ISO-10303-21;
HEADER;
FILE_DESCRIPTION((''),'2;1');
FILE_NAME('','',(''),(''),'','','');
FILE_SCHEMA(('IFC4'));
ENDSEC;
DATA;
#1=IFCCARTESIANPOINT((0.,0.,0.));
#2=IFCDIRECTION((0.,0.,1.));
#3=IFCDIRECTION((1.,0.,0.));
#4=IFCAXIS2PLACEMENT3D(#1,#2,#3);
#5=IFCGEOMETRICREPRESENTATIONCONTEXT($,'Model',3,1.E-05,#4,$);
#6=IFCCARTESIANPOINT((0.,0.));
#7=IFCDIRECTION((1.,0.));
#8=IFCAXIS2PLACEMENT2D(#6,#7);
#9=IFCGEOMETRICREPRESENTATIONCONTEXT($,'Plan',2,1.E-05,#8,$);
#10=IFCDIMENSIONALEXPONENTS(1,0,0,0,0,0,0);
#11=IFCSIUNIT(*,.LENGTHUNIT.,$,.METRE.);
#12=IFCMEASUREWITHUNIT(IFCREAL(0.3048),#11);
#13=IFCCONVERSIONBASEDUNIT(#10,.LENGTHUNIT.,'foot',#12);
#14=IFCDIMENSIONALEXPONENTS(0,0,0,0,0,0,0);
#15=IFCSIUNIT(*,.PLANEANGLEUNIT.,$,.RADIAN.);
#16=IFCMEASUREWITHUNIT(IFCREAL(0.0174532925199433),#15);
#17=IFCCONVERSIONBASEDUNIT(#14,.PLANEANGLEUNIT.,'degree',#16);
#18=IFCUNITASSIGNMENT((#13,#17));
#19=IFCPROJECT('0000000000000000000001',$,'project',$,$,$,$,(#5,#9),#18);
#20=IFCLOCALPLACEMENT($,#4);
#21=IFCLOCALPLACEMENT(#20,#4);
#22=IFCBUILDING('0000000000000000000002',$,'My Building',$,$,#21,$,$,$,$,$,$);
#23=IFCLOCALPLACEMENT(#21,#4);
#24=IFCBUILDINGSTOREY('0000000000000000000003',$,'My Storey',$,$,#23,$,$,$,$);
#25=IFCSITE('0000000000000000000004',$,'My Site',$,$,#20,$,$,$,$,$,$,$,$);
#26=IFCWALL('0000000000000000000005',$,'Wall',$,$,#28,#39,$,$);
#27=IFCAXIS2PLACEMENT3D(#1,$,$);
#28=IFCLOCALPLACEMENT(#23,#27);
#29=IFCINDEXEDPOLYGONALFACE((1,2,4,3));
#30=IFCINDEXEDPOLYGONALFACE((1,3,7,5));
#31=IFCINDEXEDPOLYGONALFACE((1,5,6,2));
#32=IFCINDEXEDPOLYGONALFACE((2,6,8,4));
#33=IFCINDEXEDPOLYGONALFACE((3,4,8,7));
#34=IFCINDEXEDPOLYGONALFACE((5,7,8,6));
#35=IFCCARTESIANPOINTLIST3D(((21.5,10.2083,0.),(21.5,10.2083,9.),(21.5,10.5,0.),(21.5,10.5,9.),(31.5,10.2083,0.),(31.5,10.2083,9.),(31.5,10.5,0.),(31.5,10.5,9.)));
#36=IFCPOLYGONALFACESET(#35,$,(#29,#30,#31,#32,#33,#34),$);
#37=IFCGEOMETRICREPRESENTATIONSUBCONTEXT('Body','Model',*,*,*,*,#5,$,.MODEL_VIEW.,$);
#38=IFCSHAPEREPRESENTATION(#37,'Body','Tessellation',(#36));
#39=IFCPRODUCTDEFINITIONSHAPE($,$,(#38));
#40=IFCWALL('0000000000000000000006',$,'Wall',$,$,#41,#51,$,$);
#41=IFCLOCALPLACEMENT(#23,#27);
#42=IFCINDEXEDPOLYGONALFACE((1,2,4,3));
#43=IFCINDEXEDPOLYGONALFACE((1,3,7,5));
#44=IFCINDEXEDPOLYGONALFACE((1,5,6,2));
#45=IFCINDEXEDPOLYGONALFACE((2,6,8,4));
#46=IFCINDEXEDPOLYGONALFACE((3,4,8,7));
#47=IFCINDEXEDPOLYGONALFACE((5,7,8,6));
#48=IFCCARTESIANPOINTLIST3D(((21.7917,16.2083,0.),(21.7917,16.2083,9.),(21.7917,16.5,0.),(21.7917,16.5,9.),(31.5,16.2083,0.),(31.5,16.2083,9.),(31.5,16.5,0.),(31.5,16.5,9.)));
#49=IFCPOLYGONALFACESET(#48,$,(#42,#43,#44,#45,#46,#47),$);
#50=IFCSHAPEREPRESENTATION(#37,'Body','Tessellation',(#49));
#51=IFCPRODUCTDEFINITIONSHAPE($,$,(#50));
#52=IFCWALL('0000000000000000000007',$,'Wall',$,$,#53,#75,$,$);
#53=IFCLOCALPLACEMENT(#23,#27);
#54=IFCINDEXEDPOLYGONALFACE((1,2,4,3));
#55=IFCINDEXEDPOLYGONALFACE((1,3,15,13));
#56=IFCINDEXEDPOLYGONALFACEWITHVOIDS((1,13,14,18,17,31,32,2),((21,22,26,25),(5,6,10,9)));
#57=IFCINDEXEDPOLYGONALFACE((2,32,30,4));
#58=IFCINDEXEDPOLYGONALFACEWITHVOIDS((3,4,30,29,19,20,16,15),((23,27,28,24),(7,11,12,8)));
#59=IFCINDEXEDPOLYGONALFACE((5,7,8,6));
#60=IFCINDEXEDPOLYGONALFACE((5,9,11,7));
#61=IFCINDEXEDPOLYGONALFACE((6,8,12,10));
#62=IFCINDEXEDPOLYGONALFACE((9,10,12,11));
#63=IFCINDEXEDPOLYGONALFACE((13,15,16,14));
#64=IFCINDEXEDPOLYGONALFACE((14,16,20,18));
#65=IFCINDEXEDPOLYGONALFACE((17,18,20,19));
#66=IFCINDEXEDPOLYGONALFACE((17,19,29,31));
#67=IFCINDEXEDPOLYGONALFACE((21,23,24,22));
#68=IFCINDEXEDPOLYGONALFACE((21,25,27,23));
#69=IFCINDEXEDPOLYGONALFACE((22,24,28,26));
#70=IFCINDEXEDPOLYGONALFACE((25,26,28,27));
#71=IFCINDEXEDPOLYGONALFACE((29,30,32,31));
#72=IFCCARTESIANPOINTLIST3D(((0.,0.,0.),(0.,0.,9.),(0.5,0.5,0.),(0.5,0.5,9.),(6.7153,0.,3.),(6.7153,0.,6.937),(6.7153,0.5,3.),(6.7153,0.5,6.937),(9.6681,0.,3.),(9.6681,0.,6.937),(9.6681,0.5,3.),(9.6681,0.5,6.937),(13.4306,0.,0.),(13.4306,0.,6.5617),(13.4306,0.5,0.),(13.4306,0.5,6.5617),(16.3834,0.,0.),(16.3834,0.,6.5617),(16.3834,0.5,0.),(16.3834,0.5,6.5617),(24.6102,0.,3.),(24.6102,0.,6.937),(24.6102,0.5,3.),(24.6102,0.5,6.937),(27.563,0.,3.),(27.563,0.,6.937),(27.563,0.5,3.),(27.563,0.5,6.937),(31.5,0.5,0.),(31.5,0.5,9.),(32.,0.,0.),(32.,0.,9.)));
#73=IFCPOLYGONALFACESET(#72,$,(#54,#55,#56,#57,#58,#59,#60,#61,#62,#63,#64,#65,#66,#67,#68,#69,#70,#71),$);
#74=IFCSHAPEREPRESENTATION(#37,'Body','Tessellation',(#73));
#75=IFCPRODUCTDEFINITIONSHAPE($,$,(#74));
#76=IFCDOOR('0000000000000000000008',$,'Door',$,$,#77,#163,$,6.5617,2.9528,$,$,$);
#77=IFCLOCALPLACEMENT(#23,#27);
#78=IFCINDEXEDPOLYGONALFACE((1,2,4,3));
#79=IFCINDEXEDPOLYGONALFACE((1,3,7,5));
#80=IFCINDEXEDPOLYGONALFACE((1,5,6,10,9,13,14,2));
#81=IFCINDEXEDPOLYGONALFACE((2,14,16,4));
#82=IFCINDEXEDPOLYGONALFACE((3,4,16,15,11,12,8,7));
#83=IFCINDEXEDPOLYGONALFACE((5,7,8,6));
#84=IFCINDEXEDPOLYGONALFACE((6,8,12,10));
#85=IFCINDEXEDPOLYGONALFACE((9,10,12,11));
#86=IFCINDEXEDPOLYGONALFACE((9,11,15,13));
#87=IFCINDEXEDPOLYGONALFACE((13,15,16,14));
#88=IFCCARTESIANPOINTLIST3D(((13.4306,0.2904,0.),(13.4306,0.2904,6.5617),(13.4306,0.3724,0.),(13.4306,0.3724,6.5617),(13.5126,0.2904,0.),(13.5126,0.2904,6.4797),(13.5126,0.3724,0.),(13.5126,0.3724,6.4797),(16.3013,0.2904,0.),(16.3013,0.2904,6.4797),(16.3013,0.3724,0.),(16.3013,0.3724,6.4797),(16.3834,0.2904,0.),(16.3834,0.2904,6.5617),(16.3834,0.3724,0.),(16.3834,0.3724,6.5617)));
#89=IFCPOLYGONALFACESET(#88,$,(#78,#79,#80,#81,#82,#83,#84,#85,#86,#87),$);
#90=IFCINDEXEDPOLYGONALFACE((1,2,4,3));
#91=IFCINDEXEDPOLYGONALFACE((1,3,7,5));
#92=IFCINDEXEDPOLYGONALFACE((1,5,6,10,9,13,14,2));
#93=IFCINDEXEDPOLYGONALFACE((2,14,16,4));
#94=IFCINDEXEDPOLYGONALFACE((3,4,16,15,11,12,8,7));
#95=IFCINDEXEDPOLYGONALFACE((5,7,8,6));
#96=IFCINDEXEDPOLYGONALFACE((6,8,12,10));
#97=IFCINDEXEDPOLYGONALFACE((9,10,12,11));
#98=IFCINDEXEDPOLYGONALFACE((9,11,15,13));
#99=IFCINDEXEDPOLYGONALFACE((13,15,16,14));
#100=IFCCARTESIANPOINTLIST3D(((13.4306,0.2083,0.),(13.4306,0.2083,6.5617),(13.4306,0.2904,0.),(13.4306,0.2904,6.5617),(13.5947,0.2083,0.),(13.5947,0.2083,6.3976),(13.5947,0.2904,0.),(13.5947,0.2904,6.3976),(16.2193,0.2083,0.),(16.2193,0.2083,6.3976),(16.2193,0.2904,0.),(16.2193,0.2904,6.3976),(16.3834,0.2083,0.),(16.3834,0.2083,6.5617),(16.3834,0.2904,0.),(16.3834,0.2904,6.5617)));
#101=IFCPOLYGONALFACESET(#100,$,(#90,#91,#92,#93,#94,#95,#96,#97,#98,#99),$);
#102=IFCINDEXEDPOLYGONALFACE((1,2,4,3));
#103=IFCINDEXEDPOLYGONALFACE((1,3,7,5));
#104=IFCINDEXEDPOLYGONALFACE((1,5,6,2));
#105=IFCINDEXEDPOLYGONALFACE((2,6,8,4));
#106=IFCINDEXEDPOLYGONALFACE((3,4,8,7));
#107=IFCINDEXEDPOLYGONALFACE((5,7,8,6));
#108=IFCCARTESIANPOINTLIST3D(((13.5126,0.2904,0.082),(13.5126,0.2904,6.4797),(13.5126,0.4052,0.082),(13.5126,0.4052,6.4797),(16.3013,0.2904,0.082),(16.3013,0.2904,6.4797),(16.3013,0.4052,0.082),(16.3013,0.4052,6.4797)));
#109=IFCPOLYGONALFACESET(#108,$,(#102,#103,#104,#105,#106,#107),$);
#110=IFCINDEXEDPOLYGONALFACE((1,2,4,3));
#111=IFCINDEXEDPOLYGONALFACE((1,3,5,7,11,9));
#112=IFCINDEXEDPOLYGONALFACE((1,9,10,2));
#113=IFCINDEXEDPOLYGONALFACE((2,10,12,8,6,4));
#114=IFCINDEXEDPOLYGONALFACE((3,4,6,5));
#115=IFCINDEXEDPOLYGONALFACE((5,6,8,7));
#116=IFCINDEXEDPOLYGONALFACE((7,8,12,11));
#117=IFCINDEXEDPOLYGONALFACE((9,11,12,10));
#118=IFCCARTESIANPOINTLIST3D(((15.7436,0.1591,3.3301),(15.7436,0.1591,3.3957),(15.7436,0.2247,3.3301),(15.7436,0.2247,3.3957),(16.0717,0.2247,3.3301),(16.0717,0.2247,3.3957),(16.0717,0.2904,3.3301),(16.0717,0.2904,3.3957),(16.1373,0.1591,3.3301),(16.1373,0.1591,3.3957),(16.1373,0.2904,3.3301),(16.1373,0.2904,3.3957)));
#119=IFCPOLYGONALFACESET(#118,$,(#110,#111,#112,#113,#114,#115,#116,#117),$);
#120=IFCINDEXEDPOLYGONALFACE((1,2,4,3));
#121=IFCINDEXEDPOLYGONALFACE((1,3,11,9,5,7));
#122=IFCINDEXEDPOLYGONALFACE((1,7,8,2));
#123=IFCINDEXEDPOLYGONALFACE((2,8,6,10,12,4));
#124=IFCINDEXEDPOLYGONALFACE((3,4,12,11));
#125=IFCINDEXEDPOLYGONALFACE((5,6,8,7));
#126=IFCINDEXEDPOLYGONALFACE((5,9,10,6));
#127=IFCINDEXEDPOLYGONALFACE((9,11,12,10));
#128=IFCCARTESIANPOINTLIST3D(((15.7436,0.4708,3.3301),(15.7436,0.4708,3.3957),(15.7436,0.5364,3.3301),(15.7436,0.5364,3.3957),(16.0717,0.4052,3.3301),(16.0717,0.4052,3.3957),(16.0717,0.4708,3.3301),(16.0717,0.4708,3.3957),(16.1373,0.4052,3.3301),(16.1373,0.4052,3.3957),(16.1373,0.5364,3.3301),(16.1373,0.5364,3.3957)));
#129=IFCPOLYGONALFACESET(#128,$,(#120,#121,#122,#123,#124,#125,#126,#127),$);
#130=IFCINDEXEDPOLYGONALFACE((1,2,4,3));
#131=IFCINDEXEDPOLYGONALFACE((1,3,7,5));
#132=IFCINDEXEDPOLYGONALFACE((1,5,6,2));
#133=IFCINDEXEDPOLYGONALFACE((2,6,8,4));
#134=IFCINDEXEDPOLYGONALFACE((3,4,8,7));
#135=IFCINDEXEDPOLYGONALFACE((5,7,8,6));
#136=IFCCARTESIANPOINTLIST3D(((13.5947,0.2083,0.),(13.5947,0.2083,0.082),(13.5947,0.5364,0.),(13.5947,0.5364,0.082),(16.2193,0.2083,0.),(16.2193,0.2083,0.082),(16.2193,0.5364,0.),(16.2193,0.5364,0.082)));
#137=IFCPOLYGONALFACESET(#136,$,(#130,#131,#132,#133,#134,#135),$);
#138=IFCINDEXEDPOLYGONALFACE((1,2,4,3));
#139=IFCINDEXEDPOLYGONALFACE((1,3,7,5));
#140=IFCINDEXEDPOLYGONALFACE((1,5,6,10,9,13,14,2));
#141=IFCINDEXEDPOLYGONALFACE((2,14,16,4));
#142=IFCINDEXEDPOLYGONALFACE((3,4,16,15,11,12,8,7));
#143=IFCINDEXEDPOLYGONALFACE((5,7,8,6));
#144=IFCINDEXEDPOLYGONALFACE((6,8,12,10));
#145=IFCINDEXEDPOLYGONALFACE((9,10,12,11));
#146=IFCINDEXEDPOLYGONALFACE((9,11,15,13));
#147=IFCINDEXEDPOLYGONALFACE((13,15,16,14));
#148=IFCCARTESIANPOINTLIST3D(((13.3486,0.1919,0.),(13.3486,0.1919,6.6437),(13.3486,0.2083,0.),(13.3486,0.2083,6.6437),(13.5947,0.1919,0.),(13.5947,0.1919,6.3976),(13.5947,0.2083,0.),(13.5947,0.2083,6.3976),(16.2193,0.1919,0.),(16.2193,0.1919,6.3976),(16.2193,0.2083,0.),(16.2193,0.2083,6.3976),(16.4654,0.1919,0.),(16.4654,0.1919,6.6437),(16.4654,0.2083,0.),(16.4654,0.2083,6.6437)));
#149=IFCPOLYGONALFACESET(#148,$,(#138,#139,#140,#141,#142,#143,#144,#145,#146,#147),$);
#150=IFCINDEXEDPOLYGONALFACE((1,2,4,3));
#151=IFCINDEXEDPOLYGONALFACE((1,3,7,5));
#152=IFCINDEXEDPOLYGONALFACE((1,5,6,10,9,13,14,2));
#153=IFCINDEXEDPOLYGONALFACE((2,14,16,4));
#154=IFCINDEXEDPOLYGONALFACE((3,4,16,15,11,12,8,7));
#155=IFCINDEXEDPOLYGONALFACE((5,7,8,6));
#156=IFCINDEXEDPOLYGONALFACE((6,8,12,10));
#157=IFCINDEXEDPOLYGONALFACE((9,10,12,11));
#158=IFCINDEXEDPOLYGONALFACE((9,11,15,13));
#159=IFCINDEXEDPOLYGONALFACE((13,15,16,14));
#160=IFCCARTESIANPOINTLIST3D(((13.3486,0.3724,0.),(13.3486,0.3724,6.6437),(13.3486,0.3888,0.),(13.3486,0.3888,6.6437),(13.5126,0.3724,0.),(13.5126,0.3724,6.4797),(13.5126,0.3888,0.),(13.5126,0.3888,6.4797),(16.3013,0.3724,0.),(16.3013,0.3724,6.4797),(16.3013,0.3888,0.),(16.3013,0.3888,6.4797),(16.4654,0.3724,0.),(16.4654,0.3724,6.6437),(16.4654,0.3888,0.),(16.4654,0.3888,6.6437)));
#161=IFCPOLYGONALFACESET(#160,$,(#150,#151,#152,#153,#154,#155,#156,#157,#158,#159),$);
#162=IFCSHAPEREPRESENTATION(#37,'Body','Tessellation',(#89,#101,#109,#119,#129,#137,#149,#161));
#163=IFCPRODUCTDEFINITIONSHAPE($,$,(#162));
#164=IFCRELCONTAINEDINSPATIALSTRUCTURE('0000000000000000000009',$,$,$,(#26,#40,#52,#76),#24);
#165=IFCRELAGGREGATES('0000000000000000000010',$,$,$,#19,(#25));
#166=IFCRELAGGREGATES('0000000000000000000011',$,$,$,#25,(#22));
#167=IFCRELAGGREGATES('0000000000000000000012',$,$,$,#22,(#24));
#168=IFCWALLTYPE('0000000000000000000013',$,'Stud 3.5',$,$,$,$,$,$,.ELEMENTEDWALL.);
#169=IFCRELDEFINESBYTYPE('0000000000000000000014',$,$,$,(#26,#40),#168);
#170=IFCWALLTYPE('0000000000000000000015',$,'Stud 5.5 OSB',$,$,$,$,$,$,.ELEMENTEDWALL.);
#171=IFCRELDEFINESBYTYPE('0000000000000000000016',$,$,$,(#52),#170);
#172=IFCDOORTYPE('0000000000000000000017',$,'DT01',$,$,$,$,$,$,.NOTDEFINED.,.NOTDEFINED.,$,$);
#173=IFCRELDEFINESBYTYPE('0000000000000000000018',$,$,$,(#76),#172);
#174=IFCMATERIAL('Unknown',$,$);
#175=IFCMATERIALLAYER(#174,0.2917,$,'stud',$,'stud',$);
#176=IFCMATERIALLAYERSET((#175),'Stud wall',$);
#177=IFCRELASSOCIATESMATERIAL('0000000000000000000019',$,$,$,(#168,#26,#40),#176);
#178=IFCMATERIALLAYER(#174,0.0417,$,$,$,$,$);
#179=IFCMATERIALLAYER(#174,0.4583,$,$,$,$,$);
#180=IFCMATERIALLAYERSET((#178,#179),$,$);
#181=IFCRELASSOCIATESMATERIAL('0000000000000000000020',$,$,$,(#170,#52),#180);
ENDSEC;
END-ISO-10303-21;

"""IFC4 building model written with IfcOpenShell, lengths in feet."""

from ifc_helpers import new_model, entity, si_unit, converted_unit, frame, origin_with_axes, origin_2d_with_axis, place, context, subcontext, project, spatial, line, indexed_curve, outline, extrude, clip, halfspace, shape, source, transform, mapped, material, layer, layer_set, layer_usage, type_object, type_shapes, element, fill, save


model = new_model("IFC4")

# Units and contexts
model_context = context("Model", 3, precision=1e-05, world=origin_with_axes())
plan_context = context("Plan", 2, precision=1e-05, world=origin_2d_with_axis())
body_context_1 = subcontext(model_context, "Body", "Model", "MODEL_VIEW")
body_context_2 = subcontext(plan_context, "Body", "Plan", "PLAN_VIEW")
ifc_project = project(units=[converted_unit("LENGTHUNIT", "foot", entity("IfcReal", 0.3048), si_unit("LENGTHUNIT", "METRE"), dimensions=[1, 0, 0, 0, 0, 0, 0]), converted_unit("PLANEANGLEUNIT", "degree", entity("IfcReal", 0.0174532925199433), si_unit("PLANEANGLEUNIT", "RADIAN"), dimensions=[0, 0, 0, 0, 0, 0, 0])], contexts=[model_context, plan_context])

# Site, building, storey
site_placement = place(None, origin_with_axes())
site = spatial("IfcSite", under=ifc_project, at=site_placement, Name="My Site")
building_placement = place(site_placement, origin_with_axes())
building = spatial("IfcBuilding", under=site, at=building_placement, Name="My Building")
storey_placement = place(building_placement, origin_with_axes())
storey = spatial("IfcBuildingStorey", under=building, at=storey_placement, Name="My Storey")

# Walls
ifc_material = material(Name="Unknown")
ifc_layer_1 = layer(ifc_material, 0.2917, Name="stud", Category="stud")
ifc_layer_set_1 = layer_set([ifc_layer_1], Name="Stud wall")
ifc_layer_usage_1 = layer_usage(ifc_layer_set_1, "AXIS2", "POSITIVE", 0.0)
wall_type_1 = type_object("IfcWallType", Name="Stud 3.5", PredefinedType="ELEMENTEDWALL", material=ifc_layer_set_1)
wall_1_placement = place(storey_placement, frame((31.5, 10.5, 0.0), z_axis=(0.0, 0.0, 1.0), x_axis=(-1.0, 0.000001, 0.0)))
element("IfcWall", 1, at=wall_1_placement, inside=storey, type_object=wall_type_1, material=ifc_layer_usage_1, Name="Wall", context=body_context_1, shape_type="SweptSolid", body=[
    extrude(outline(indexed_curve([(0.0, 0.0), (0.0, 0.2917), (10.0, 0.2917), (10.0, 0.0), (0.0, 0.0)], self_intersect=False)), origin_with_axes(), (0.0, 0.0, 1.0), 9.0),
])
ifc_layer_usage_2 = layer_usage(ifc_layer_set_1, "AXIS2", "POSITIVE", 0.0)
wall_2_placement = place(storey_placement, frame((31.5, 16.5, 0.0), z_axis=(0.0, 0.0, 1.0), x_axis=(-1.0, 0.000001, 0.0)))
element("IfcWall", 2, at=wall_2_placement, inside=storey, type_object=wall_type_1, material=ifc_layer_usage_2, Name="Wall", context=body_context_1, shape_type="SweptSolid", body=[
    extrude(outline(indexed_curve([(0.0, 0.0), (0.0, 0.2917), (9.7083, 0.2917), (9.7083, 0.0), (0.0, 0.0)], self_intersect=False)), origin_with_axes(), (0.0, 0.0, 1.0), 9.0),
])

# Wall, openings, door
ifc_layer_2 = layer(ifc_material, 0.0417)
ifc_layer_3 = layer(ifc_material, 0.4583)
ifc_layer_set_2 = layer_set([ifc_layer_2, ifc_layer_3])
ifc_layer_usage_3 = layer_usage(ifc_layer_set_2, "AXIS2", "POSITIVE", 0.0)
wall_type_2 = type_object("IfcWallType", Name="Stud 5.5 OSB", PredefinedType="ELEMENTEDWALL", material=ifc_layer_set_2)
wall_3_placement = place(storey_placement, origin_with_axes())
wall_3 = element("IfcWall", 3, at=wall_3_placement, inside=storey, type_object=wall_type_2, material=ifc_layer_usage_3, Name="Wall", context=body_context_1, shape_type="Clipping", body=[
    clip(clip(extrude(outline(indexed_curve([(0.0, 0.0), (0.0, 0.5), (32.0, 0.5), (32.0, 0.0), (0.0, 0.0)], self_intersect=False)), origin_with_axes(), (0.0, 0.0, 1.0), 9.0), halfspace(frame((32.0, 0.0, 0.0), z_axis=(0.707107, 0.707107, 0.0), x_axis=(0.707107, -0.707107, 0.0)), False)), halfspace(frame((0.0, 0.0, 0.0), z_axis=(-0.707106, 0.707107, 0.0), x_axis=(0.707107, 0.707106, 0.0)), False)),
])
shared_shape_1 = source(origin_with_axes(), body_context_1, "Body", "SweptSolid", [
    extrude(outline(indexed_curve([(0.0, 0.0), (2.9528, 0.0), (2.9528, 6.5617), (0.0, 6.5617)], segments=[line(1, 2, 3, 4, 1)])), frame((0.0, -1.9685, 0.0), z_axis=(0.0, -1.0, 0.0), x_axis=(1.0, 0.0, 0.0)), (0.0, 0.0, -1.0), 3.937),
])
opening_1_placement = place(wall_3_placement, frame((13.4306, 0.2083, 0.0), z_axis=(0.0, 0.0, 1.0), x_axis=(1.0, 0.0, 0.0)))
opening_1 = element("IfcOpeningElement", 4, at=opening_1_placement, cuts=wall_3, PredefinedType="OPENING", context=body_context_1, shape_type="MappedRepresentation", body=[
    mapped(shared_shape_1, transform((0.0, 0.0, 0.0), x_axis=(1.0, 0.0, 0.0), y_axis=(0.0, 1.0, 0.0), z_axis=(0.0, 0.0, 1.0), scale=1.0)),
])
shared_shape_2 = source(origin_with_axes(), body_context_1, "Body", "SweptSolid", [
    extrude(outline(indexed_curve([(0.0, 0.0), (2.9528, 0.0), (2.9528, 3.937), (0.0, 3.937)], segments=[line(1, 2, 3, 4, 1)])), frame((0.0, -1.9685, 0.0), z_axis=(0.0, -1.0, 0.0), x_axis=(1.0, 0.0, 0.0)), (0.0, 0.0, -1.0), 3.937),
])
opening_2_placement = place(wall_3_placement, frame((6.7153, 0.0, 3.0), z_axis=(0.0, 0.0, 1.0), x_axis=(1.0, 0.0, 0.0)))
element("IfcOpeningElement", 5, at=opening_2_placement, cuts=wall_3, PredefinedType="OPENING", context=body_context_1, shape_type="MappedRepresentation", body=[
    mapped(shared_shape_2, transform((0.0, 0.0, 0.0), x_axis=(1.0, 0.0, 0.0), y_axis=(0.0, 1.0, 0.0), z_axis=(0.0, 0.0, 1.0), scale=1.0)),
])
opening_3_placement = place(wall_3_placement, frame((24.6102, 0.0, 3.0), z_axis=(0.0, 0.0, 1.0), x_axis=(1.0, 0.0, 0.0)))
element("IfcOpeningElement", 6, at=opening_3_placement, cuts=wall_3, PredefinedType="OPENING", context=body_context_1, shape_type="MappedRepresentation", body=[
    mapped(shared_shape_2, transform((0.0, 0.0, 0.0), x_axis=(1.0, 0.0, 0.0), y_axis=(0.0, 1.0, 0.0), z_axis=(0.0, 0.0, 1.0), scale=1.0)),
])
door_type = type_object("IfcDoorType", Name="DT01", OperationType="NOTDEFINED", PredefinedType="NOTDEFINED")
shared_shape_3 = source(origin_with_axes(), body_context_1, "Body", "SweptSolid", [
    extrude(outline(indexed_curve([(0.0, 0.0), (0.0, 6.5617), (2.9528, 6.5617), (2.9528, 0.0), (2.8707, 0.0), (2.8707, 6.4797), (0.082, 6.4797), (0.082, 0.0)], segments=[line(1, 2, 3, 4, 5, 6, 7, 8, 1)])), frame((0.0, 0.082, 0.0), z_axis=(0.0, -1.0, 0.0), x_axis=(1.0, 0.0, 0.0)), (0.0, 0.0, -1.0), 0.082),
    extrude(outline(indexed_curve([(0.0, 0.0), (0.0, 6.5617), (2.9528, 6.5617), (2.9528, 0.0), (2.7887, 0.0), (2.7887, 6.3976), (0.164, 6.3976), (0.164, 0.0)], segments=[line(1, 2, 3, 4, 5, 6, 7, 8, 1)])), frame((0.0, 0.0, 0.0), z_axis=(0.0, -1.0, 0.0), x_axis=(1.0, 0.0, 0.0)), (0.0, 0.0, -1.0), 0.082),
    extrude(outline(indexed_curve([(0.0, 0.0), (2.7887, 0.0), (2.7887, 0.1148), (0.0, 0.1148)], segments=[line(1, 2, 3, 4, 1)])), frame((0.082, 0.082, 0.082), z_axis=(0.0, 0.0, 1.0), x_axis=(1.0, 0.0, 0.0)), (0.0, 0.0, 1.0), 6.3976),
    extrude(outline(indexed_curve([(0.0, 0.0), (0.0, -0.1312), (-0.3937, -0.1312), (-0.3937, -0.0656), (-0.0656, -0.0656), (-0.0656, 0.0)], segments=[line(1, 2, 3, 4, 5, 6, 1)])), frame((2.7067, 0.082, 3.3301), z_axis=(0.0, 0.0, 1.0), x_axis=(1.0, 0.0, 0.0)), (0.0, 0.0, 1.0), 0.0656),
    extrude(outline(indexed_curve([(0.0, 0.0), (0.0, 0.1312), (-0.3937, 0.1312), (-0.3937, 0.0656), (-0.0656, 0.0656), (-0.0656, 0.0)], segments=[line(1, 2, 3, 4, 5, 6, 1)])), frame((2.7067, 0.1969, 3.3301), z_axis=(0.0, 0.0, 1.0), x_axis=(1.0, 0.0, 0.0)), (0.0, 0.0, 1.0), 0.0656),
    extrude(outline(indexed_curve([(0.0, 0.0), (2.6247, 0.0), (2.6247, 0.3281), (0.0, 0.3281)], segments=[line(1, 2, 3, 4, 1)])), frame((0.164, 0.0, 0.0), z_axis=(0.0, 0.0, 1.0), x_axis=(1.0, 0.0, 0.0)), (0.0, 0.0, 1.0), 0.082),
    extrude(outline(indexed_curve([(0.0, 0.0), (0.0, 6.6437), (3.1168, 6.6437), (3.1168, 0.0), (2.8707, 0.0), (2.8707, 6.3976), (0.2461, 6.3976), (0.2461, 0.0)], segments=[line(1, 2, 3, 4, 5, 6, 7, 8, 1)])), frame((-0.082, -0.0164, 0.0), z_axis=(0.0, -1.0, 0.0), x_axis=(1.0, 0.0, 0.0)), (0.0, 0.0, -1.0), 0.0164),
    extrude(outline(indexed_curve([(0.0, 0.0), (0.0, 6.6437), (3.1168, 6.6437), (3.1168, 0.0), (2.9528, 0.0), (2.9528, 6.4797), (0.164, 6.4797), (0.164, 0.0)], segments=[line(1, 2, 3, 4, 5, 6, 7, 8, 1)])), frame((-0.082, 0.164, 0.0), z_axis=(0.0, -1.0, 0.0), x_axis=(1.0, 0.0, 0.0)), (0.0, 0.0, -1.0), 0.0164),
])
shared_shape_4 = source(origin_with_axes(), body_context_2, "Body", "Curve2D", [
    entity("IfcIndexedPolyCurve", entity("IfcCartesianPointList2D", [[0.0, 0.0], [0.0, 0.164], [0.082, 0.164], [0.082, 0.082], [0.164, 0.082], [0.164, 0.0]]), [entity("IfcLineIndex", [1, 2, 3, 4, 5, 6, 1])]),
    entity("IfcIndexedPolyCurve", entity("IfcCartesianPointList2D", [[2.9528, 0.0], [2.9528, 0.164], [2.8707, 0.164], [2.8707, 0.082], [2.7887, 0.082], [2.7887, 0.0]]), [entity("IfcLineIndex", [1, 2, 3, 4, 5, 6, 1])]),
    entity("IfcTrimmedCurve", entity("IfcEllipse", entity("IfcAxis2Placement2D", entity("IfcCartesianPoint", [0.1969, 0.164]), entity("IfcDirection", [1.0, 0.0])), 2.6739, 2.7887), [entity("IfcCartesianPoint", [2.8707, 0.164])], [entity("IfcCartesianPoint", [0.1969, 2.9528])], True, "CARTESIAN"),
    entity("IfcIndexedPolyCurve", entity("IfcCartesianPointList2D", [[0.082, 0.164], [0.1969, 0.164], [0.1969, 2.9528], [0.082, 2.9528]]), [entity("IfcLineIndex", [1, 2, 3, 4, 1])]),
])
type_shapes(door_type, [shared_shape_3, shared_shape_4])
door_placement = place(opening_1_placement, origin_with_axes())
door = element("IfcDoor", 7, at=door_placement, inside=storey, type_object=door_type, Name="Door", OverallHeight=6.5617, OverallWidth=2.9528, shapes=[
    shape(body_context_1, "Body", "MappedRepresentation", [mapped(shared_shape_3, transform((0.0, 0.0, 0.0), x_axis=(1.0, 0.0, 0.0), y_axis=(0.0, 1.0, 0.0), z_axis=(0.0, 0.0, 1.0), scale=1.0))]),
    shape(body_context_2, "Body", "MappedRepresentation", [mapped(shared_shape_4, transform((0.0, 0.0, 0.0), x_axis=(1.0, 0.0, 0.0), y_axis=(0.0, 1.0, 0.0), z_axis=(0.0, 0.0, 1.0), scale=1.0))]),
])
fill(opening_1, door)

save(model, "model.ifc")
